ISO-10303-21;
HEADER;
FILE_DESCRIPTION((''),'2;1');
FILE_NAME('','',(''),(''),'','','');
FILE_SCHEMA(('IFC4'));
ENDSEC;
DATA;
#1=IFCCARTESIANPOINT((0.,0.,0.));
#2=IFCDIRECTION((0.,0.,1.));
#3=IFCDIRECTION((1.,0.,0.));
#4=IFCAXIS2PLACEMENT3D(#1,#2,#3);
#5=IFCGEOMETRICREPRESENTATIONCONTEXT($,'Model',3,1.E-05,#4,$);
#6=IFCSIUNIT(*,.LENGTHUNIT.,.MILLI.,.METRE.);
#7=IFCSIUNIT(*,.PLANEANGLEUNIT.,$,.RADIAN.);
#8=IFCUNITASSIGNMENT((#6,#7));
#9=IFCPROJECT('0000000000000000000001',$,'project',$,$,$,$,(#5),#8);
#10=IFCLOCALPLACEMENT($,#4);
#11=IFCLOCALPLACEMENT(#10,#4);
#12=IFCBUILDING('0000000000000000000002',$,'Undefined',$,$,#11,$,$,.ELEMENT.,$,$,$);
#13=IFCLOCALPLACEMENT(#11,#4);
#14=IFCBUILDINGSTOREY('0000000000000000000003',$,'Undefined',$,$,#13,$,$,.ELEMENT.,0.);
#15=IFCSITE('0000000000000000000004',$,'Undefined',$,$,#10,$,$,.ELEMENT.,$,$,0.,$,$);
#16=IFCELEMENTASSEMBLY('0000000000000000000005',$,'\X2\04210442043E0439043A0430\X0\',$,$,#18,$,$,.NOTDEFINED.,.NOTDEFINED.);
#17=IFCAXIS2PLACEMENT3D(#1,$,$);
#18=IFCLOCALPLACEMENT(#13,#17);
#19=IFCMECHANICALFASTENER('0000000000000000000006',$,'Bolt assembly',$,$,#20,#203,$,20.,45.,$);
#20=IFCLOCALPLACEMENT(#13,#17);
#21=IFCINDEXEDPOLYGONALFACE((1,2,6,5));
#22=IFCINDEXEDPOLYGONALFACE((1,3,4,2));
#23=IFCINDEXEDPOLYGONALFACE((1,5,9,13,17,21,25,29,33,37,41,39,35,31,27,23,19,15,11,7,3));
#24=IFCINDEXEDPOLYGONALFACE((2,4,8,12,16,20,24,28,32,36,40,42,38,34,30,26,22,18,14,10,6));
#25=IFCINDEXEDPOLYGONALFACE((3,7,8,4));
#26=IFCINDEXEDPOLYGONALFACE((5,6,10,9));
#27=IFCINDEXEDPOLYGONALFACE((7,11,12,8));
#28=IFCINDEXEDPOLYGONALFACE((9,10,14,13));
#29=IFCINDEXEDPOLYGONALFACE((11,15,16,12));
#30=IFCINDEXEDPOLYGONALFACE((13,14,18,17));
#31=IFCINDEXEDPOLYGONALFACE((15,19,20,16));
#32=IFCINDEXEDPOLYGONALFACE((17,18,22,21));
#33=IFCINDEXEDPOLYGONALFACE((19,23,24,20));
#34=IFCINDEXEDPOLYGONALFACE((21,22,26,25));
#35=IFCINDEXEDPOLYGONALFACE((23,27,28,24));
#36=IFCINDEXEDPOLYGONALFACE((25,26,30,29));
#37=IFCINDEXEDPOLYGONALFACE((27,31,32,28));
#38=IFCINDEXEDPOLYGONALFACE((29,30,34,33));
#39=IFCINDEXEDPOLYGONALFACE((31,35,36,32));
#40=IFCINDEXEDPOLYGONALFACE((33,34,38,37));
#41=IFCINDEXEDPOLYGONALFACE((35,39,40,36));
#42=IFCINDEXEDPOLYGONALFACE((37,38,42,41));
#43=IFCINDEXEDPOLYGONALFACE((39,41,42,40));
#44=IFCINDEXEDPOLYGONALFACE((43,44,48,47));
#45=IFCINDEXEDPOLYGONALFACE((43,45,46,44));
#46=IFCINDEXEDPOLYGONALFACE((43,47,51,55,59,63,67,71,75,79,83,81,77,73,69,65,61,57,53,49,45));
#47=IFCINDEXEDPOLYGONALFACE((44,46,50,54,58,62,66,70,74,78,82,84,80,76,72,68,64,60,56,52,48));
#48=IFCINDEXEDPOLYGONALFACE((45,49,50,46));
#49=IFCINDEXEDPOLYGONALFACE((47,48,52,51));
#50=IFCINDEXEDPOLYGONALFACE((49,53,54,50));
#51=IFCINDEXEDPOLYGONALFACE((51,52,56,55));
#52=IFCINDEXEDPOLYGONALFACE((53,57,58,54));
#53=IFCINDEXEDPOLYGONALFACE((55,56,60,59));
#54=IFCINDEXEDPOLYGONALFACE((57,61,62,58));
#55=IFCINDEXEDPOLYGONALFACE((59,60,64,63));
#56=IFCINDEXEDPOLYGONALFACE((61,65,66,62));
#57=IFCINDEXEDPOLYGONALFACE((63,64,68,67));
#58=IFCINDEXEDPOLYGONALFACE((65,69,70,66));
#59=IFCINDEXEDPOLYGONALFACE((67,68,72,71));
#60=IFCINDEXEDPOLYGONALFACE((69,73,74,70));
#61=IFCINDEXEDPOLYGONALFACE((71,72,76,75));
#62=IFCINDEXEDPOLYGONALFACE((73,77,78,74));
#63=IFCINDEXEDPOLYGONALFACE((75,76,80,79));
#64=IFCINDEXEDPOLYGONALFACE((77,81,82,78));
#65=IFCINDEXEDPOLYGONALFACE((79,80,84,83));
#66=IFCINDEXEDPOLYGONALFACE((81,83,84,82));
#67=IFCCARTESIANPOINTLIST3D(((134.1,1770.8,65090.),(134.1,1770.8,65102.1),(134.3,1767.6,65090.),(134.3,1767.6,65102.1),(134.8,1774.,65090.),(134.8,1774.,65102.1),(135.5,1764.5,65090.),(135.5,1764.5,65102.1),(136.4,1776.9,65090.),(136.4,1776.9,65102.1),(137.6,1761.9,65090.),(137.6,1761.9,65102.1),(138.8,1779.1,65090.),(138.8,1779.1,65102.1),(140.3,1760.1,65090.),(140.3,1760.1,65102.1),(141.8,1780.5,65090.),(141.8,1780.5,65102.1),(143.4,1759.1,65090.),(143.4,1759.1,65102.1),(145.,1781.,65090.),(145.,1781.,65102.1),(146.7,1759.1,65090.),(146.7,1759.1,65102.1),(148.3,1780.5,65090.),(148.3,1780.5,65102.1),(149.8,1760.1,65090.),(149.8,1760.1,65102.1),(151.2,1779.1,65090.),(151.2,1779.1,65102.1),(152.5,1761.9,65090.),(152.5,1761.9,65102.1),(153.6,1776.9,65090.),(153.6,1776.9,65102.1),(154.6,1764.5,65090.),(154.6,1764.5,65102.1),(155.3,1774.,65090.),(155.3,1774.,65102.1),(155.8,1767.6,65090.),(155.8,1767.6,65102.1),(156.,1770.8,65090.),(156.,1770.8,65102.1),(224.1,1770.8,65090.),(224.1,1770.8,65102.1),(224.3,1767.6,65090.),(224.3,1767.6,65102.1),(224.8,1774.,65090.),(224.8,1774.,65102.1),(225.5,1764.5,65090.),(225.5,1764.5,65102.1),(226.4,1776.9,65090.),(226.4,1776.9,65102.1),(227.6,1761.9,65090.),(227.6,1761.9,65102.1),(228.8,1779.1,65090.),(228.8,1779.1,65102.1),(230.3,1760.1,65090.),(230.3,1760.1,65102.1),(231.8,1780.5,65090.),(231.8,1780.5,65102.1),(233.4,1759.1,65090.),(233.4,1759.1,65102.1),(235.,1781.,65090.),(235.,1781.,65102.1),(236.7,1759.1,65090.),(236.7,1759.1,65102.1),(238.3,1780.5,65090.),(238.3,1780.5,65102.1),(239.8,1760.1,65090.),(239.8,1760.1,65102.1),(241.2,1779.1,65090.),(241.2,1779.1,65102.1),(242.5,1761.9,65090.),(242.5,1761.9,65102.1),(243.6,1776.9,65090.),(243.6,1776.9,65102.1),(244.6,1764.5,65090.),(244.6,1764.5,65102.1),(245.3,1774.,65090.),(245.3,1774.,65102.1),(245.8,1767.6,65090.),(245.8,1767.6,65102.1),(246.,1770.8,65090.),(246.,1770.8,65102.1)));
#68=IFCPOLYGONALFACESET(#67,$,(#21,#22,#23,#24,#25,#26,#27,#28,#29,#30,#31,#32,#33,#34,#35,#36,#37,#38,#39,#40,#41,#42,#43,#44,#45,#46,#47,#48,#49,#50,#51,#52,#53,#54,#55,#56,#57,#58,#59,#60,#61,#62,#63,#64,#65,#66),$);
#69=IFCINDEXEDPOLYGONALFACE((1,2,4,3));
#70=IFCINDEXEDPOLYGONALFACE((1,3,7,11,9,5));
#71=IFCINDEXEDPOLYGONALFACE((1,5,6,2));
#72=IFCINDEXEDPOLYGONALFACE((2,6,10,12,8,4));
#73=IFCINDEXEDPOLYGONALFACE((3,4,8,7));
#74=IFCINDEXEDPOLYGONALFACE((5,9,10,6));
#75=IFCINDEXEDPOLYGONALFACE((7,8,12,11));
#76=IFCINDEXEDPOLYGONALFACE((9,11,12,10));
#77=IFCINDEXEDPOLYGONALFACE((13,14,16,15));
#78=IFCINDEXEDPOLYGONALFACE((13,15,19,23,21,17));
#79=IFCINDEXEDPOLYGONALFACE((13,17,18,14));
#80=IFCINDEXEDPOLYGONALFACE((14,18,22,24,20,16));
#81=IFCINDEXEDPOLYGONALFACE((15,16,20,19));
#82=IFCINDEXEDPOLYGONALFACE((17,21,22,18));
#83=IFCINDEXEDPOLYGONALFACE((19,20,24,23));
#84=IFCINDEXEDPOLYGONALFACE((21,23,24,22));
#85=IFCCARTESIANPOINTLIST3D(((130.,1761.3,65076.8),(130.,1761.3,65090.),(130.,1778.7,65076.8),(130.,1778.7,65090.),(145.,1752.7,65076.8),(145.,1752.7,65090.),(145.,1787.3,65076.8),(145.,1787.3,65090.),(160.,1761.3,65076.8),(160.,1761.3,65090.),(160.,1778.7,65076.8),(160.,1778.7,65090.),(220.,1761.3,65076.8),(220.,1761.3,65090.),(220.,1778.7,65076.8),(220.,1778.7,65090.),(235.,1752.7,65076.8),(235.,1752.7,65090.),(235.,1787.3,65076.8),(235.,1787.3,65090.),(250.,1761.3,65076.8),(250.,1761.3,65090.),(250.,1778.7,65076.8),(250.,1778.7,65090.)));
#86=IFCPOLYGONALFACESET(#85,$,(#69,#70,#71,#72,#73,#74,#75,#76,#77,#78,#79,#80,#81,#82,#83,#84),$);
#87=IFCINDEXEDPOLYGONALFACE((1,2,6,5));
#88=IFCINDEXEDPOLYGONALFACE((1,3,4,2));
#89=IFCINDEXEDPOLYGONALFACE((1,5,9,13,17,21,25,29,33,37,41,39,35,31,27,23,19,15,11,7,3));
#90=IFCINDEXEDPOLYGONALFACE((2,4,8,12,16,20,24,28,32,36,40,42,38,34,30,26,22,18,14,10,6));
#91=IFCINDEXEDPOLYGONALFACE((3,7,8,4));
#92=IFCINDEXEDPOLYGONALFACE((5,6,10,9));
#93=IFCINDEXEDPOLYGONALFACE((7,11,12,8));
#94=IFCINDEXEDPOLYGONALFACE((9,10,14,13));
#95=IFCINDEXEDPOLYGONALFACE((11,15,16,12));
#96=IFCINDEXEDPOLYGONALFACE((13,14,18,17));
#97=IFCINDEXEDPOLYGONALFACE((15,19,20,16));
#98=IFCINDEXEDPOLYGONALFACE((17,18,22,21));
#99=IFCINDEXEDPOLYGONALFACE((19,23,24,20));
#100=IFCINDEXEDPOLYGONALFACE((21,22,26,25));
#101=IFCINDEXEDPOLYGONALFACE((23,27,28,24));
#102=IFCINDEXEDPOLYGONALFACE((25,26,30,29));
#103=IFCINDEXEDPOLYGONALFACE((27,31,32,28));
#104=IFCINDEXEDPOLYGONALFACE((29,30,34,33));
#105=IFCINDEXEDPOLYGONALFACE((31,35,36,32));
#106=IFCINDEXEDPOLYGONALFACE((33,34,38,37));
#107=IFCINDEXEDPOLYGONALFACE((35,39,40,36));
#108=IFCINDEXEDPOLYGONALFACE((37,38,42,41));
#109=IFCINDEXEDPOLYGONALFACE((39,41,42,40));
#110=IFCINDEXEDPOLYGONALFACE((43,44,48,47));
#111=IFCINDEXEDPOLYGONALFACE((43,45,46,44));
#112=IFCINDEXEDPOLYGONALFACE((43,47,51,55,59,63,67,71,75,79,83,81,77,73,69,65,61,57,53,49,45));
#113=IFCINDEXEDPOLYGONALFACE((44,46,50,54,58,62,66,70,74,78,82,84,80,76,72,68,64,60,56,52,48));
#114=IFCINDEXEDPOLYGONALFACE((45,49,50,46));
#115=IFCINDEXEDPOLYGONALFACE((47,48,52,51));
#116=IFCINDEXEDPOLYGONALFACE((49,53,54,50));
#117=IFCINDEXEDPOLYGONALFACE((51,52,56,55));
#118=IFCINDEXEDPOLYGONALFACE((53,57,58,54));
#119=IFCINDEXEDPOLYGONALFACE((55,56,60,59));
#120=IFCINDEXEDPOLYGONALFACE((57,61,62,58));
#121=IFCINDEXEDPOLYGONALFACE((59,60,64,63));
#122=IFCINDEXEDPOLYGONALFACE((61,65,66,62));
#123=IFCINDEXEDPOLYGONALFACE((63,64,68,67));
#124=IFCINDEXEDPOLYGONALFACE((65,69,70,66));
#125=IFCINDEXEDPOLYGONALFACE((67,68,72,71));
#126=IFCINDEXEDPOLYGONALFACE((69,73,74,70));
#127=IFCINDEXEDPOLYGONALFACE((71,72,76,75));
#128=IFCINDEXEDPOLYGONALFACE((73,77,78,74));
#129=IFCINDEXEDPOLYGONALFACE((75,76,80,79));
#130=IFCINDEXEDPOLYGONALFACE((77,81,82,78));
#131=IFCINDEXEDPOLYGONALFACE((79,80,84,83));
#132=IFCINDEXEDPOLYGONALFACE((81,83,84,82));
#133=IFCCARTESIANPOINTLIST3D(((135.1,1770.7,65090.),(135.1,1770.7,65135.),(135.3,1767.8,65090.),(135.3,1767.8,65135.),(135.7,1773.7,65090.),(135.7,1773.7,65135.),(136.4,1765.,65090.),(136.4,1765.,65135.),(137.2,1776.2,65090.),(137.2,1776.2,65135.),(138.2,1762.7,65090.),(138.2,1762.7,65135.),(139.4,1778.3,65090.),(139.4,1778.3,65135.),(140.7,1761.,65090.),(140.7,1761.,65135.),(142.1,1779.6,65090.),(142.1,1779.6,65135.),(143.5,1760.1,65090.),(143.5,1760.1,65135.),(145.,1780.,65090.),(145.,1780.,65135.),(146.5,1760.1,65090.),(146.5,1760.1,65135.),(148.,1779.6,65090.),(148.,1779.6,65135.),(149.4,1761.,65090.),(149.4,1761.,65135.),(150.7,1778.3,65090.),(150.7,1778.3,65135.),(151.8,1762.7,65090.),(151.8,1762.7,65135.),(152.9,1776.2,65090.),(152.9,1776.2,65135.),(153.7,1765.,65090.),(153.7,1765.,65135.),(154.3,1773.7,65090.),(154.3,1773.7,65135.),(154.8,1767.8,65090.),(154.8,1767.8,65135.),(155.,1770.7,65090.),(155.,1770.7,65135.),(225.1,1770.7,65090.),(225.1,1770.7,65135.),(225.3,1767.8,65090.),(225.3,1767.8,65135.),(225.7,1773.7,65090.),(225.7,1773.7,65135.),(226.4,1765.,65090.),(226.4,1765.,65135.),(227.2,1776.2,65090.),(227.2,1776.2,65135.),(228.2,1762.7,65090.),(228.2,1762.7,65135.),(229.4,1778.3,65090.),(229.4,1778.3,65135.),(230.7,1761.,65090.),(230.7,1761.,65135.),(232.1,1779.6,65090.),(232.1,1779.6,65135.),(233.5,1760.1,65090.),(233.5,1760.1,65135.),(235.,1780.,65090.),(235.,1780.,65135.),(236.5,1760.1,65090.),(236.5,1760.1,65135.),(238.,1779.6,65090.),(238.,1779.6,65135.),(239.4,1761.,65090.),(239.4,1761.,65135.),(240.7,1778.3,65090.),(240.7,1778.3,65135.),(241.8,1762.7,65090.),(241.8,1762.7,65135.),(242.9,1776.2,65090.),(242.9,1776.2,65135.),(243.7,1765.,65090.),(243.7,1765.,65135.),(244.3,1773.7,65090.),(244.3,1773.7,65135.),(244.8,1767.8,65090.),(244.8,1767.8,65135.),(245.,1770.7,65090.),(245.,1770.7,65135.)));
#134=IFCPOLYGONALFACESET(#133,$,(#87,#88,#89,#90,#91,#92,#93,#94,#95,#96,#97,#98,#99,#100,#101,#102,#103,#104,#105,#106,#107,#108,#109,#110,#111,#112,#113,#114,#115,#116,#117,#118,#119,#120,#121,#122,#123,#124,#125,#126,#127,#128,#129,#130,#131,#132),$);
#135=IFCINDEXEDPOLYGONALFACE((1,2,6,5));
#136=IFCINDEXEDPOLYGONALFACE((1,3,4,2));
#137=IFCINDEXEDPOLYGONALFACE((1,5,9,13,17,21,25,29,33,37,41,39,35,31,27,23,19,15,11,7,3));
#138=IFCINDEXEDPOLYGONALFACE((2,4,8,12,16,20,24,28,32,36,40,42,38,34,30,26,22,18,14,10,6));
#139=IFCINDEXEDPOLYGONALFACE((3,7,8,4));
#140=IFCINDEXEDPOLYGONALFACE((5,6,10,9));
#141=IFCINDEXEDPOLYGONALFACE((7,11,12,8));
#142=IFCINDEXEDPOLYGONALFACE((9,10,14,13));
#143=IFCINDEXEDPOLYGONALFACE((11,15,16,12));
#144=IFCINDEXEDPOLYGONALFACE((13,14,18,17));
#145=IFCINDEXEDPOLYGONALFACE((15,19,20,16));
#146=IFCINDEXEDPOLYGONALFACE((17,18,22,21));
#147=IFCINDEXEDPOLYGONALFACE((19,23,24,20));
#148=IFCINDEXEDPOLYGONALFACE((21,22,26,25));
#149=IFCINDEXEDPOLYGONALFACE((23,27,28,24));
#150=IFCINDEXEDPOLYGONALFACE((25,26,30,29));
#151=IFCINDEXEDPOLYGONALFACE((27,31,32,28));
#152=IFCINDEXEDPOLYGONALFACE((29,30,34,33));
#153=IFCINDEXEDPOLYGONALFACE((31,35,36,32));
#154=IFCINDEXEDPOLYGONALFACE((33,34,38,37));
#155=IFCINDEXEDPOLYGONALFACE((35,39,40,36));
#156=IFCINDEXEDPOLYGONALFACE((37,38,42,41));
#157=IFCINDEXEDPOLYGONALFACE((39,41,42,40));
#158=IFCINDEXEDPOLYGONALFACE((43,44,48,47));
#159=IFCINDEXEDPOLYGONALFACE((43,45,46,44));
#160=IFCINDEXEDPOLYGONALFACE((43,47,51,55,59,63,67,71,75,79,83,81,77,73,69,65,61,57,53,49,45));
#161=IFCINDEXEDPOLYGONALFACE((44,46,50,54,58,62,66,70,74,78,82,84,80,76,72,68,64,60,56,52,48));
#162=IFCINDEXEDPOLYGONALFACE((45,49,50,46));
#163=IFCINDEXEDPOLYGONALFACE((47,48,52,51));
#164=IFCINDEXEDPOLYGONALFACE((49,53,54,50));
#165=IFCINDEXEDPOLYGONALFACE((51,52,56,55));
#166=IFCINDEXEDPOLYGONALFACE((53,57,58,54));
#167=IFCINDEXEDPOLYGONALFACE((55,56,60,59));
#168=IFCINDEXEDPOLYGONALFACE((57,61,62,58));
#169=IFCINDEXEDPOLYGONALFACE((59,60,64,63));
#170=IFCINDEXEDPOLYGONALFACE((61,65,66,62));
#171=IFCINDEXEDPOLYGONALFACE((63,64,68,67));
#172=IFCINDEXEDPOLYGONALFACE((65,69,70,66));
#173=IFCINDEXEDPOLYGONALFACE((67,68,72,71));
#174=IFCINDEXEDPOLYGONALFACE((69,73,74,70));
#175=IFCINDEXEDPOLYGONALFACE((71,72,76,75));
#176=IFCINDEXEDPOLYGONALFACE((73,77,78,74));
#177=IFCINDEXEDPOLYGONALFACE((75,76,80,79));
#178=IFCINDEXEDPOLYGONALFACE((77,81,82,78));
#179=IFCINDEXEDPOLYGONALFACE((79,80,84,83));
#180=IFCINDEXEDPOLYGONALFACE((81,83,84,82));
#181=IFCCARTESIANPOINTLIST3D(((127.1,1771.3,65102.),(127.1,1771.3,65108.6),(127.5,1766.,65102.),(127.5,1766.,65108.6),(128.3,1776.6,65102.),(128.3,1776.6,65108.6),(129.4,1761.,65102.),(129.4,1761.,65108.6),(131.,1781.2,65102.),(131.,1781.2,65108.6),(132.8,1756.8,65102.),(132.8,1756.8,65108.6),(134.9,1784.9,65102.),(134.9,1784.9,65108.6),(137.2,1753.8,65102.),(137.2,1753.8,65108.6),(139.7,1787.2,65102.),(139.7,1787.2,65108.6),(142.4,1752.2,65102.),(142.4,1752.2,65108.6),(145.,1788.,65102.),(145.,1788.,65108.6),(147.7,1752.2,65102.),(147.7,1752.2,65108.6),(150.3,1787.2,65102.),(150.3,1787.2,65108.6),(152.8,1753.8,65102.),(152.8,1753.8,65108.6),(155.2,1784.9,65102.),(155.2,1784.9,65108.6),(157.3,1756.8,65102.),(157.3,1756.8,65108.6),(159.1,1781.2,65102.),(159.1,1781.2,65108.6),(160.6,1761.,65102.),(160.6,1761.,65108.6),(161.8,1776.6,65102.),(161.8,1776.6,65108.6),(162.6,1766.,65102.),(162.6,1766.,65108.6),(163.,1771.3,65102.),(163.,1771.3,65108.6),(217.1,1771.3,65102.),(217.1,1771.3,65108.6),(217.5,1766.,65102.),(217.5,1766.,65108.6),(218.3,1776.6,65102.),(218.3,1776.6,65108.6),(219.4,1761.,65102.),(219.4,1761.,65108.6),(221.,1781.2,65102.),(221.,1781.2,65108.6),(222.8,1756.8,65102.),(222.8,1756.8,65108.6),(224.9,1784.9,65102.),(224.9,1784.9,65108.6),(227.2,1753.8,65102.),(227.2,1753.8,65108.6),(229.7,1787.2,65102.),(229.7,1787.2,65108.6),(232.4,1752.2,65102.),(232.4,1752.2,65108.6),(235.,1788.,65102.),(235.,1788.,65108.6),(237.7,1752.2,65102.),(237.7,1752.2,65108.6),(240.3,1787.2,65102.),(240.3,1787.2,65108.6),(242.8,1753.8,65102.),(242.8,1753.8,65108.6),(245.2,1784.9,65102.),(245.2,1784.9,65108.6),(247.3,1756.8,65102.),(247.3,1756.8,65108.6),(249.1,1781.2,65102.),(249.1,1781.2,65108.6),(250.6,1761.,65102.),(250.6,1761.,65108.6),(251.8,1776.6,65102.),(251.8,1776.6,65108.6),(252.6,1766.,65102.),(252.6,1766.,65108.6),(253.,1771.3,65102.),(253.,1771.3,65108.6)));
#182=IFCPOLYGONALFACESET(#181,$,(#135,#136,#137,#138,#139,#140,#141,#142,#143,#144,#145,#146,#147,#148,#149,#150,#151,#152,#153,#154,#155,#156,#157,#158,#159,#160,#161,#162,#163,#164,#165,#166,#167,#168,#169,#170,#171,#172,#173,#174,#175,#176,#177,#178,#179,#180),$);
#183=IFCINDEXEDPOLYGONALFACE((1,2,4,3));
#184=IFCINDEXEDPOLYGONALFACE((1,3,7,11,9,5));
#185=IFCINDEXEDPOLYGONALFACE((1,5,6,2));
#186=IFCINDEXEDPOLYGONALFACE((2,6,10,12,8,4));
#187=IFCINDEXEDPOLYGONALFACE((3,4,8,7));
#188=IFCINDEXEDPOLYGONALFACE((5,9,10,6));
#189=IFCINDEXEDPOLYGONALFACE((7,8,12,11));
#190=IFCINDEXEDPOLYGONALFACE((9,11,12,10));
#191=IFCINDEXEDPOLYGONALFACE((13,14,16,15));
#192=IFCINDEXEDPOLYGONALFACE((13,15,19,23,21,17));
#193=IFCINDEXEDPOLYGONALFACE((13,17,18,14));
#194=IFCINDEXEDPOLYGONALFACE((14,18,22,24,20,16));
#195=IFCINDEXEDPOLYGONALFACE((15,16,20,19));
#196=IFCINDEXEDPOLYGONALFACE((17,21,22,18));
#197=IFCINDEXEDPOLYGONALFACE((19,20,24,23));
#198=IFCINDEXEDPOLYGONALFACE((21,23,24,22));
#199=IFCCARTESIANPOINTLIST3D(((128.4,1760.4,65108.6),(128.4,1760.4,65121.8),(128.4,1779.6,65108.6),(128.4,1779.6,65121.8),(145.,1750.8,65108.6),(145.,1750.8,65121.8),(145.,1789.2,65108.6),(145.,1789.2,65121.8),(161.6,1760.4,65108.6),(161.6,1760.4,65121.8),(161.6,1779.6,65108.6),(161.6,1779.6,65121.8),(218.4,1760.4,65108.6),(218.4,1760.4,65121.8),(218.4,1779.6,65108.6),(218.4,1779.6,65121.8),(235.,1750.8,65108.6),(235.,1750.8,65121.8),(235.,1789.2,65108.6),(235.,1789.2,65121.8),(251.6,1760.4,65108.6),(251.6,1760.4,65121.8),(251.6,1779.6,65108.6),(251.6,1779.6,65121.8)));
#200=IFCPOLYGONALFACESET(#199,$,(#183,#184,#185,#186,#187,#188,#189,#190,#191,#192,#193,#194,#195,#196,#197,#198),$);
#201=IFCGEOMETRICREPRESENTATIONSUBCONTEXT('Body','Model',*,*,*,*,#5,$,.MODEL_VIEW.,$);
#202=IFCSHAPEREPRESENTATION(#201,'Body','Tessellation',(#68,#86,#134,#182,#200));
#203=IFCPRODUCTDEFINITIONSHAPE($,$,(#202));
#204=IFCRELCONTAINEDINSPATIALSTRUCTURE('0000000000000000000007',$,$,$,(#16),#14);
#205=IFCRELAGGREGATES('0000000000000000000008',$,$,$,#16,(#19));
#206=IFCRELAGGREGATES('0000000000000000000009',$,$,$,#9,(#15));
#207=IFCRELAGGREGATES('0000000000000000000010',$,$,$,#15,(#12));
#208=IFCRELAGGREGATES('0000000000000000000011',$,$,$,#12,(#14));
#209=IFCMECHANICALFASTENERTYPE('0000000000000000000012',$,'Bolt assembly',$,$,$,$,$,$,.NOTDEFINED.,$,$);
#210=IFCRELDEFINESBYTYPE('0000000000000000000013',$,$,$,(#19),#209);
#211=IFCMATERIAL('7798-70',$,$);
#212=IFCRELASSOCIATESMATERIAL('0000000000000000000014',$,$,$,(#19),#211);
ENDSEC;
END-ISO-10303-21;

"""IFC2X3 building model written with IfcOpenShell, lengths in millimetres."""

from ifc_helpers import new_model, si_unit, frame, origin_with_axes, origin_2d_with_axis, place, context, subcontext, project, spatial, polyline, circle, outline, extrude, source, transform, mapped, material, type_object, element, aggregate, save


model = new_model("IFC2X3")

# Units and contexts
model_context = context("Model", 3, precision=1e-05, world=origin_with_axes())
body_context = subcontext(model_context, "Body", "Model", "MODEL_VIEW")
ifc_project = project(units=[si_unit("LENGTHUNIT", "METRE", prefix="MILLI"), si_unit("PLANEANGLEUNIT", "RADIAN")], contexts=[model_context])

# Site, building, storey
site_placement = place(None, origin_with_axes())
site = spatial("IfcSite", under=ifc_project, at=site_placement, Name="Undefined", CompositionType="ELEMENT", RefElevation=0.0)
building_placement = place(site_placement, origin_with_axes())
building = spatial("IfcBuilding", under=site, at=building_placement, Name="Undefined", CompositionType="ELEMENT")
storey_placement = place(building_placement, origin_with_axes())
storey = spatial("IfcBuildingStorey", under=building, at=storey_placement, Name="Undefined", CompositionType="ELEMENT", Elevation=0.0)

# Element assembly
assembly_1_placement = place(storey_placement, origin_with_axes())
assembly_1 = element("IfcElementAssembly", 1, at=assembly_1_placement, inside=storey, Name="Стойка", AssemblyPlace="NOTDEFINED", PredefinedType="NOTDEFINED")

# Shared definitions
mechanical_fastener_type = type_object("IfcMechanicalFastenerType", Name="Bolt assembly")
ifc_material_1 = material(Name="7798-70")

# Mechanical fastener
shared_shape_1 = source(origin_with_axes(), body_context, "Body", "SweptSolid", [
    extrude(circle(Radius=11.0, at=origin_2d_with_axis()), frame((0.0, -0.5, 0.0), z_axis=(0.0, 1.0, 0.0), x_axis=(1.0, 0.0, 0.0)), (0.0, 0.0, 1.0), 12.1),
    extrude(outline(polyline([(17.3, 0.0), (8.7, 15.0), (-8.7, 15.0), (-17.3, 0.0), (-8.7, -15.0), (8.7, -15.0), (17.3, 0.0)])), frame((0.0, -13.7, 0.0), z_axis=(0.0, 1.0, 0.0), x_axis=(1.0, 0.0, 0.0)), (0.0, 0.0, 1.0), 13.2),
    extrude(circle(Radius=10.0, at=origin_2d_with_axis()), frame((0.0, -0.5, 0.0), z_axis=(0.0, 1.0, 0.0), x_axis=(1.0, 0.0, 0.0)), (0.0, 0.0, 1.0), 45.0),
    extrude(circle(Radius=18.0, at=origin_2d_with_axis()), frame((0.0, 11.5, 0.0), z_axis=(0.0, 1.0, 0.0), x_axis=(1.0, 0.0, 0.0)), (0.0, 0.0, 1.0), 6.6),
    extrude(outline(polyline([(19.2, 0.0), (9.6, 16.6), (-9.6, 16.6), (-19.2, 0.0), (-9.6, -16.6), (9.6, -16.6), (19.2, 0.0)])), frame((0.0, 18.1, 0.0), z_axis=(0.0, 1.0, 0.0), x_axis=(1.0, 0.0, 0.0)), (0.0, 0.0, 1.0), 13.2),
])
mechanical_fastener_1_placement = place(assembly_1_placement, frame((190.0, 1520.0, 65090.5), z_axis=(1.0, 0.0, 0.0), x_axis=(0.0, 1.0, 0.0)))
mechanical_fastener_1 = element("IfcMechanicalFastener", 2, at=mechanical_fastener_1_placement, type_object=mechanical_fastener_type, material=ifc_material_1, Name="Bolt assembly", NominalDiameter=20.0, NominalLength=45.0, context=body_context, shape_type="MappedRepresentation", body=[
    mapped(shared_shape_1, transform((250.0, 0.0, -45.0))),
    mapped(shared_shape_1, transform((250.0, 0.0, 45.0))),
])
aggregate(assembly_1, [mechanical_fastener_1])

save(model, "model.ifc")
